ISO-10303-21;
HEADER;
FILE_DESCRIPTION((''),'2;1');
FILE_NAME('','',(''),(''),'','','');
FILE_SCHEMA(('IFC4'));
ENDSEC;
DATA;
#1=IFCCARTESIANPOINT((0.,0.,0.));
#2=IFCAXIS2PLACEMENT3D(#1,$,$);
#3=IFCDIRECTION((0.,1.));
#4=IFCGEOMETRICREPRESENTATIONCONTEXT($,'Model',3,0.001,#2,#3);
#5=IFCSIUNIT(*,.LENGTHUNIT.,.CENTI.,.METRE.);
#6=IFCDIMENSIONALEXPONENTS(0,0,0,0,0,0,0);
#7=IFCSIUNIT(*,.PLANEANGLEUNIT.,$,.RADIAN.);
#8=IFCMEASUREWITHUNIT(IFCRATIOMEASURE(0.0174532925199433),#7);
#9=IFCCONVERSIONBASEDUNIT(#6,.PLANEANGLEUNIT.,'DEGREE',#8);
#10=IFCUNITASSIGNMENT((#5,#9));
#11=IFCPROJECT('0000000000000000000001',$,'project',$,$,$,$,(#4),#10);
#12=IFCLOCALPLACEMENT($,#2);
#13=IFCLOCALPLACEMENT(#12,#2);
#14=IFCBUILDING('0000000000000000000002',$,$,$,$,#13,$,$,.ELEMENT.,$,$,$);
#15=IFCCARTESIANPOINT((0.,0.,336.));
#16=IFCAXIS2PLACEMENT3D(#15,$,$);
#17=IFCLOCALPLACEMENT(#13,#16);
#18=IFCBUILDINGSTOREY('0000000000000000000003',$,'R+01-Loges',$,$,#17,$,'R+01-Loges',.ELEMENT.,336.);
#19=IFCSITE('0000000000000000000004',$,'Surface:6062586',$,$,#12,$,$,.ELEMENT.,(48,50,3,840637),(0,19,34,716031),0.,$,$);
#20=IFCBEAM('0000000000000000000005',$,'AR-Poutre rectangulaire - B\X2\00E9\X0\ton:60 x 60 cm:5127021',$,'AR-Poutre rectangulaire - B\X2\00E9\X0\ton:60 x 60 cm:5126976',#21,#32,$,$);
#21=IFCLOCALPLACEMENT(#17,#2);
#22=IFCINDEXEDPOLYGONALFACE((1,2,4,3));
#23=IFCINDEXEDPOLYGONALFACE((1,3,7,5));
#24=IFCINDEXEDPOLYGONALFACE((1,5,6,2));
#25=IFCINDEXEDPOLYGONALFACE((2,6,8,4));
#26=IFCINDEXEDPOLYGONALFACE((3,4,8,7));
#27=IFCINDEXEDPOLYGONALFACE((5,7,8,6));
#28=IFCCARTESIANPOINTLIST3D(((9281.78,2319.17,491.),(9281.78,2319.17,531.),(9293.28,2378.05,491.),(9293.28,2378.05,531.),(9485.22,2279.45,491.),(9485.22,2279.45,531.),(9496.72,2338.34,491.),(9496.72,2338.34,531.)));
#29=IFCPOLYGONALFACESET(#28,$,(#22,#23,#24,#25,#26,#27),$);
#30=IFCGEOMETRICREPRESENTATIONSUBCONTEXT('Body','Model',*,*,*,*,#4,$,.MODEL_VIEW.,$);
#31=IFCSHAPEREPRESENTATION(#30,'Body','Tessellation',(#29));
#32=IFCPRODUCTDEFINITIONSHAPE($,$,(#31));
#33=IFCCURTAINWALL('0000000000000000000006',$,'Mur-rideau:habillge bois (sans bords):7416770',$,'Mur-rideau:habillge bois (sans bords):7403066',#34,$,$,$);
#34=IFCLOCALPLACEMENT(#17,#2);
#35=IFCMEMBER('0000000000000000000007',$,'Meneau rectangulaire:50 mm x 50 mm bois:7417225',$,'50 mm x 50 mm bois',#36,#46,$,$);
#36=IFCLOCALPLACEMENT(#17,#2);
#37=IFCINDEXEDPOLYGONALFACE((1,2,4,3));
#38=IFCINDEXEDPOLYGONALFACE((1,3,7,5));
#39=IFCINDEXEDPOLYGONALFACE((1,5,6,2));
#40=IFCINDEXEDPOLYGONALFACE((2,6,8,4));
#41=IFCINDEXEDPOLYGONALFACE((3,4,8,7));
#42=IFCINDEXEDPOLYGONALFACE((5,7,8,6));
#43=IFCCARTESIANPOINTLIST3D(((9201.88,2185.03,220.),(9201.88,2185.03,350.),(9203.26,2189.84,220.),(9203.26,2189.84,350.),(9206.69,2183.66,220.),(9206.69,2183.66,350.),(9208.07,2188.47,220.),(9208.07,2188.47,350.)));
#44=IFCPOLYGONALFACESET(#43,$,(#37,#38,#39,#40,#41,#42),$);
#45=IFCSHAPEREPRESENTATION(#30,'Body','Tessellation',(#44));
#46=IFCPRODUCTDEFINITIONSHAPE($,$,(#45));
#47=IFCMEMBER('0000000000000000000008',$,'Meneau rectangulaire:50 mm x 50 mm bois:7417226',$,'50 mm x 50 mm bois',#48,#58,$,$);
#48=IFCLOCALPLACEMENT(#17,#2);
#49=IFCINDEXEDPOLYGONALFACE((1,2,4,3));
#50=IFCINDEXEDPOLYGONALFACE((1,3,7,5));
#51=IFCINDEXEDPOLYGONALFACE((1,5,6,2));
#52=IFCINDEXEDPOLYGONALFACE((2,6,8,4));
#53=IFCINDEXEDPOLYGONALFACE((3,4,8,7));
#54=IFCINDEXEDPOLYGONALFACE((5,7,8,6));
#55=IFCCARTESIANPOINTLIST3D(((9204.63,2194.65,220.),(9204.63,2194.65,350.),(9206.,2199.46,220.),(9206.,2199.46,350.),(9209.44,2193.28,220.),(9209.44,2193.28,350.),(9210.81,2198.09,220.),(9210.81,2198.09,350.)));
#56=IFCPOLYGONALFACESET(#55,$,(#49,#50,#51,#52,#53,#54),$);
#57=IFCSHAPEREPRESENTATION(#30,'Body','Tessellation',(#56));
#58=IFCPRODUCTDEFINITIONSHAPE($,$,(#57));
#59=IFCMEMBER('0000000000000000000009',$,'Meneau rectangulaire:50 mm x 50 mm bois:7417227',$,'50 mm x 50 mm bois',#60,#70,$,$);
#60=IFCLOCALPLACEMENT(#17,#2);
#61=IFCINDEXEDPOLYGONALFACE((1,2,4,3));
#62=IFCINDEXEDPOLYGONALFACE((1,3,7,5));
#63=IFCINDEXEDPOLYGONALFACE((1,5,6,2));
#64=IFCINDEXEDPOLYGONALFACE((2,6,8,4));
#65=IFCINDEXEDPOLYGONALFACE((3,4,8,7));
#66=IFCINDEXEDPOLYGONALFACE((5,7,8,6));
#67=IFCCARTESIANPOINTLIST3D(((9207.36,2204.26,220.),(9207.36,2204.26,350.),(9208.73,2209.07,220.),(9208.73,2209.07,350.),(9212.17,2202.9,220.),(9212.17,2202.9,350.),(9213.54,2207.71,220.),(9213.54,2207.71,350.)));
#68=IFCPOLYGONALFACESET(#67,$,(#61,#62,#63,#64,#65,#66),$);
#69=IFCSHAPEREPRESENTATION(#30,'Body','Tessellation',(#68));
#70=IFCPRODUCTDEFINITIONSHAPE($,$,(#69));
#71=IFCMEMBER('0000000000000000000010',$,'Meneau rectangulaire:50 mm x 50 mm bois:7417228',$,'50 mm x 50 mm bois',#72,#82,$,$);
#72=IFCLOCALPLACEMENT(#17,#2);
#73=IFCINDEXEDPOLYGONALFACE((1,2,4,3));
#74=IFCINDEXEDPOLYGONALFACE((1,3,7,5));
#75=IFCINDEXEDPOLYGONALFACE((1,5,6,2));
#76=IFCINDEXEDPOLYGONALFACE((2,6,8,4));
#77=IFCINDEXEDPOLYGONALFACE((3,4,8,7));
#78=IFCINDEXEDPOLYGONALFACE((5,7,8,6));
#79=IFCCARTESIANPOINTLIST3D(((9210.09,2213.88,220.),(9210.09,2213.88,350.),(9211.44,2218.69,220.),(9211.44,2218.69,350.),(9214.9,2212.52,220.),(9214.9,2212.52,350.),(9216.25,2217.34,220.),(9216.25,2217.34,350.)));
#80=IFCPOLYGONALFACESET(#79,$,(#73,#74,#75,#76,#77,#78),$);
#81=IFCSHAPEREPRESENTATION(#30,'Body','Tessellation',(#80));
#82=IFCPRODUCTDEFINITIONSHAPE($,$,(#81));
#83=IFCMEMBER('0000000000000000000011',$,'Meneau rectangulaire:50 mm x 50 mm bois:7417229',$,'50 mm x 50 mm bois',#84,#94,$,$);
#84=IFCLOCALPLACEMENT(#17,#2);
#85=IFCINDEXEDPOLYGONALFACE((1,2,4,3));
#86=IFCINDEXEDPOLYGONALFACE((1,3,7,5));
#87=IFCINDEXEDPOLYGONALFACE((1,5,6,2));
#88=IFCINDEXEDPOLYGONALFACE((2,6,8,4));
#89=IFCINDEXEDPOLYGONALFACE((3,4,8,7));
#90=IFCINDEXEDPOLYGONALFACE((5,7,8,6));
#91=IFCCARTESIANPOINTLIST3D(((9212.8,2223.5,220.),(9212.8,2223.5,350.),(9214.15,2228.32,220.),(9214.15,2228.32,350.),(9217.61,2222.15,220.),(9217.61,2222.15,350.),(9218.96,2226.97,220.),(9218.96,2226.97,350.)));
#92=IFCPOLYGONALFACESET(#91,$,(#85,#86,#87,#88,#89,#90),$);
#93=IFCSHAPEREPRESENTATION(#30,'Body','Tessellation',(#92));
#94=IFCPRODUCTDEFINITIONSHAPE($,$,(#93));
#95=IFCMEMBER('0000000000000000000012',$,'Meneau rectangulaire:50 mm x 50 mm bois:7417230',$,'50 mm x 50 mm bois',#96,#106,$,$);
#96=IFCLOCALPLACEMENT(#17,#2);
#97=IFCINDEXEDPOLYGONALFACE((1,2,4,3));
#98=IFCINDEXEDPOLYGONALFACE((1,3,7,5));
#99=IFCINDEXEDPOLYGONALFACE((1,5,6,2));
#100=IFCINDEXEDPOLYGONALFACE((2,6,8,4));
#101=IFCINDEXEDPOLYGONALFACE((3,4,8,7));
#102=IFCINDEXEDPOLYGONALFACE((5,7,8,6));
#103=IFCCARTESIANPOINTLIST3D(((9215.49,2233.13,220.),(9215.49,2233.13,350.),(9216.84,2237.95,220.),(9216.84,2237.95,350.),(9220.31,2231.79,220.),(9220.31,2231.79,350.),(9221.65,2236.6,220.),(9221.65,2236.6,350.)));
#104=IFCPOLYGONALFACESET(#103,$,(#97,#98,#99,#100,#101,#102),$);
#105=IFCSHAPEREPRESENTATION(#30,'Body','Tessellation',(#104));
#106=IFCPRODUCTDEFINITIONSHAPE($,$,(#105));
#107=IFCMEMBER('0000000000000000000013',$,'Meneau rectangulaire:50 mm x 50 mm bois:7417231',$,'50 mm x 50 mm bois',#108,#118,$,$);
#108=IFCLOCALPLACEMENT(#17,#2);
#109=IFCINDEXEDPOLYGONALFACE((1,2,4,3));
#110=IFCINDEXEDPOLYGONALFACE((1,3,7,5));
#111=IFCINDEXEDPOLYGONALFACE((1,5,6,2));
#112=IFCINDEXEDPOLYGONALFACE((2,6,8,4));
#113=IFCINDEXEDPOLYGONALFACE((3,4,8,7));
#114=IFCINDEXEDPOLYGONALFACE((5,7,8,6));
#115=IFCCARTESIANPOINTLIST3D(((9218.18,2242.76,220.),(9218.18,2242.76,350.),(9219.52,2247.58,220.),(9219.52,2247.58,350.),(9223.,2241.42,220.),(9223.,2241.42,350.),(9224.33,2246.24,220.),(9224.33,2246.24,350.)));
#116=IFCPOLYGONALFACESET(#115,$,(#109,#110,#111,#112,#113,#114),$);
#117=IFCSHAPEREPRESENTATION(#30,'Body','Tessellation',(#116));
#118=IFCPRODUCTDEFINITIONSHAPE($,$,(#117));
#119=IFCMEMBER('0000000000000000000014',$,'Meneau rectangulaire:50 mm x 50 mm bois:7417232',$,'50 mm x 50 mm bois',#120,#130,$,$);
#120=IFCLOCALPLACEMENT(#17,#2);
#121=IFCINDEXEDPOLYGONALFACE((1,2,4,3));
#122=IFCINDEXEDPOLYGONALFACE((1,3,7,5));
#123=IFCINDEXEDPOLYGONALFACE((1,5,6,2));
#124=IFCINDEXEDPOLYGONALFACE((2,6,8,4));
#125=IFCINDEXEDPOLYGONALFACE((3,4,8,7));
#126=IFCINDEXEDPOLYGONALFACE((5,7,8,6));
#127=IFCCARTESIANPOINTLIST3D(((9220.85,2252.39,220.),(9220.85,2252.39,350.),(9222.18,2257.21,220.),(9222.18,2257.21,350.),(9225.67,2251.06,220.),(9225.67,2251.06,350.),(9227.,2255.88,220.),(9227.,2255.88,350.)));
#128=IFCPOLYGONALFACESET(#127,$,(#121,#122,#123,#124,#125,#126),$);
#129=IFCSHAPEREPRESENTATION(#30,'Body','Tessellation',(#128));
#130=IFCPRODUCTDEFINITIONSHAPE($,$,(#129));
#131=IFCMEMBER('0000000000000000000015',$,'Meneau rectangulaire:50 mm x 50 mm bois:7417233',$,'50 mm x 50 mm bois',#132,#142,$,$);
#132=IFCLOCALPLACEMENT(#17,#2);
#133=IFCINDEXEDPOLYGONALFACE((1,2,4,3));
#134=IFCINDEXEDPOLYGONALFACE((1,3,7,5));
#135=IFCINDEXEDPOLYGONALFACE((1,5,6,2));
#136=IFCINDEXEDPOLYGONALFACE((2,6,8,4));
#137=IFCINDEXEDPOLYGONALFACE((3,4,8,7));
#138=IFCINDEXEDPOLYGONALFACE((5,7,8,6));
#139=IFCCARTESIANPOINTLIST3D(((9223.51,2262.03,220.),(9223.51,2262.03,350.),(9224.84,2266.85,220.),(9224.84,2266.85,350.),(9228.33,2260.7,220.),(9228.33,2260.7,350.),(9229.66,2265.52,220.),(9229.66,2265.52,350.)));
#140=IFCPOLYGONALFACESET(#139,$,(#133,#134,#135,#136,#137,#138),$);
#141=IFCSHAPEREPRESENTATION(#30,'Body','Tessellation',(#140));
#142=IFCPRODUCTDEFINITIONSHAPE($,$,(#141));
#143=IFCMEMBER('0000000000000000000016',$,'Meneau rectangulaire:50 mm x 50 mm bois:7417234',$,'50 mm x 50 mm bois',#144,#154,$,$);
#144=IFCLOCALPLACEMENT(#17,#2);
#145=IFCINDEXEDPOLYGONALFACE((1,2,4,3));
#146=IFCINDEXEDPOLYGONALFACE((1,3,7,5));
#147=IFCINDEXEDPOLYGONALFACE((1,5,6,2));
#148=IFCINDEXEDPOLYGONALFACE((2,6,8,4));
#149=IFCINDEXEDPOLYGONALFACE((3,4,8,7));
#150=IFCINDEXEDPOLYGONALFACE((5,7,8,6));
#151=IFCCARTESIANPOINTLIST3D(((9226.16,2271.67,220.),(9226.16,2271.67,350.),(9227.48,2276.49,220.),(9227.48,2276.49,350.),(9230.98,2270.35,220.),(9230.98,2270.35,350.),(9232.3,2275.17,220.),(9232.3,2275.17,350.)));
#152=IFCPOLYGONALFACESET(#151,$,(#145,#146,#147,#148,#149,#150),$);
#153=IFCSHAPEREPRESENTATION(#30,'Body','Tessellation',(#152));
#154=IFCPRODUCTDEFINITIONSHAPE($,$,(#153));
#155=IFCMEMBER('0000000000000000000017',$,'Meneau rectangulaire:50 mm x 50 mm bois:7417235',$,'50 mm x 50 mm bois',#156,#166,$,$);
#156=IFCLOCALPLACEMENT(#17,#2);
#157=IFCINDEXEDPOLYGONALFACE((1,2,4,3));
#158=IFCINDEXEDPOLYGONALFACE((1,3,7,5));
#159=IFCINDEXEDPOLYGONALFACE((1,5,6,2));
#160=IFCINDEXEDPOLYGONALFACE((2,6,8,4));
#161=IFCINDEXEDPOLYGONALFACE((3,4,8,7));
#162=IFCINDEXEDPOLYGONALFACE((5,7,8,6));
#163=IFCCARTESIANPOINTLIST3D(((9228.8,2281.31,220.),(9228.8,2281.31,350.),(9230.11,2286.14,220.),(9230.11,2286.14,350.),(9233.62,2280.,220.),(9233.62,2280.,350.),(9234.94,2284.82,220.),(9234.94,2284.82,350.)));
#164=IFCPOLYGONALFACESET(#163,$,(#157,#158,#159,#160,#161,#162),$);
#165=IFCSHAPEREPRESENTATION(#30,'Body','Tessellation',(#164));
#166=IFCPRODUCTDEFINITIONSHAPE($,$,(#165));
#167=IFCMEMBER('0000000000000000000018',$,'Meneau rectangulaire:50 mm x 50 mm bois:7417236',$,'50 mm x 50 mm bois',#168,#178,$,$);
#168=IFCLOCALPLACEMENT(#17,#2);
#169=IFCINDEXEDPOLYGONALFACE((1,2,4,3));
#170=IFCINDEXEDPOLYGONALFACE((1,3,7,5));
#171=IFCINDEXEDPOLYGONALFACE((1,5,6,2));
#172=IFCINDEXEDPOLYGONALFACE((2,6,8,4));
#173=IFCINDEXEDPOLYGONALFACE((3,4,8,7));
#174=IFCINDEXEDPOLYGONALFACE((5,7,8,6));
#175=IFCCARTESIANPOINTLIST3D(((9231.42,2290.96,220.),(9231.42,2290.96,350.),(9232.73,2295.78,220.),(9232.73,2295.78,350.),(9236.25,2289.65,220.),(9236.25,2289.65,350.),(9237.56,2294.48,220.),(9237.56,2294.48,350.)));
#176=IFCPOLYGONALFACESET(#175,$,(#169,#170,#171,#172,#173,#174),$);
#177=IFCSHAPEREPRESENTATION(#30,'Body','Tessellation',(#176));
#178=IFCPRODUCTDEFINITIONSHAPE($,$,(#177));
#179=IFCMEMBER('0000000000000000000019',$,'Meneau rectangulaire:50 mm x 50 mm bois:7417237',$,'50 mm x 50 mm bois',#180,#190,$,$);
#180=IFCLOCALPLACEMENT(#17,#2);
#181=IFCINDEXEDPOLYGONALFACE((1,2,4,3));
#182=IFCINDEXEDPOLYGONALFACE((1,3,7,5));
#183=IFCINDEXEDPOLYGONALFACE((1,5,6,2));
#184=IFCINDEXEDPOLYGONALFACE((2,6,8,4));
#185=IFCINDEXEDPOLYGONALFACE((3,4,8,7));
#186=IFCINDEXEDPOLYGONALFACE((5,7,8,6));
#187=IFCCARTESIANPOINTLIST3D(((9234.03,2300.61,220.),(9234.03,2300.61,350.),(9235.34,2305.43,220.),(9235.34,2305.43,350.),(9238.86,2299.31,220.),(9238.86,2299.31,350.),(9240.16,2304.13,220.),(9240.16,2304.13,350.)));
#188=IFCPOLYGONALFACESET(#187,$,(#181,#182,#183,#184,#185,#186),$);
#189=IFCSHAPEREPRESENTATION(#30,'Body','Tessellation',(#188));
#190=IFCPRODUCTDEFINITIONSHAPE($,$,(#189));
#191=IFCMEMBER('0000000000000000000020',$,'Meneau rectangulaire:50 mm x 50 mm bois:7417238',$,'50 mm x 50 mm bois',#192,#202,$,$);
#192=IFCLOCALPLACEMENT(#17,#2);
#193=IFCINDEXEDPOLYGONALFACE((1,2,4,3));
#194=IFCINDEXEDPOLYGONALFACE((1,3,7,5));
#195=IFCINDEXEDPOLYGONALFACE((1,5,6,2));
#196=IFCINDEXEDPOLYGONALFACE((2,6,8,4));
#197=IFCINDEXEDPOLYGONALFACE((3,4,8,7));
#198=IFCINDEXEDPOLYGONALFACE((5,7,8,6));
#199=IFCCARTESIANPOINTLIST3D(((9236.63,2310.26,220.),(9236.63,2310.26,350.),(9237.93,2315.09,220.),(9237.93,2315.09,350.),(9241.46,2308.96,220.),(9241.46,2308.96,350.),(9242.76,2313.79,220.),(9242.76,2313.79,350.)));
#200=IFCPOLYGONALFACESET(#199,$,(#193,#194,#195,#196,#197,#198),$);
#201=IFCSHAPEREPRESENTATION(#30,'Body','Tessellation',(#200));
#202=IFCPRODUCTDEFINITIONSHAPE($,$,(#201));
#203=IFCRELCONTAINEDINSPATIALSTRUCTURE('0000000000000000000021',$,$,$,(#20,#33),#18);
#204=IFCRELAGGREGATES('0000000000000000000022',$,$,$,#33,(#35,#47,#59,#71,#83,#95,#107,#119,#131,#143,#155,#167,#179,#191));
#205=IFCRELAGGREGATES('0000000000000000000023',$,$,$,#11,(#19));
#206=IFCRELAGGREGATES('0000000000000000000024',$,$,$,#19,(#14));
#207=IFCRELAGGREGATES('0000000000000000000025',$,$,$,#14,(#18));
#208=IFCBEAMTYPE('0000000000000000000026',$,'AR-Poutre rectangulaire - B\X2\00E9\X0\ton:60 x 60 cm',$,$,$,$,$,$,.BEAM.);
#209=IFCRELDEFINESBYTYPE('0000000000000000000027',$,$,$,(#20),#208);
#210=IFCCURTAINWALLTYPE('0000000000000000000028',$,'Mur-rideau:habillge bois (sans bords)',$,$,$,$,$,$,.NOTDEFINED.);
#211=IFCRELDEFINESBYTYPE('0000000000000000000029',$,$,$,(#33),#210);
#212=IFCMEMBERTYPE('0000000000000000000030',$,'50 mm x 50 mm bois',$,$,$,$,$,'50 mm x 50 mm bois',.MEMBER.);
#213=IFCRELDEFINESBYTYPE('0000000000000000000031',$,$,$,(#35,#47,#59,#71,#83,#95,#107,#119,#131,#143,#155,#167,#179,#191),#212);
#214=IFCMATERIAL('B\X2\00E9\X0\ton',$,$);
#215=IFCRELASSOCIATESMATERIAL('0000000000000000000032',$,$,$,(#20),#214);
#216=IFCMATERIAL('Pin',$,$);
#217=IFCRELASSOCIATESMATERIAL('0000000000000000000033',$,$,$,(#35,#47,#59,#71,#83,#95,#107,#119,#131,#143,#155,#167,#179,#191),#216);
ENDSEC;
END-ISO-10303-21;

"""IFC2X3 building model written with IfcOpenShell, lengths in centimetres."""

from ifc_helpers import new_model, entity, si_unit, converted_unit, direction, frame, origin, origin_2d_with_axis, place, context, subcontext, project, spatial, rectangle, extrude, source, transform, mapped, material, type_object, type_shapes, element, aggregate, save


model = new_model("IFC2X3")

# Units and contexts
model_context = context("Model", 3, precision=0.001, world=origin(), true_north=direction((0.0, 1.0)))
body_context = subcontext(model_context, "Body", "Model", "MODEL_VIEW")
ifc_project = project(units=[si_unit("LENGTHUNIT", "METRE", prefix="CENTI"), converted_unit("PLANEANGLEUNIT", "DEGREE", entity("IfcRatioMeasure", 0.0174532925199433), si_unit("PLANEANGLEUNIT", "RADIAN"), dimensions=[0, 0, 0, 0, 0, 0, 0])], contexts=[model_context])

# Site, building, storey
site_placement = place(None, origin())
site = spatial("IfcSite", under=ifc_project, at=site_placement, Name="Surface:6062586", CompositionType="ELEMENT", RefLatitude=(48, 50, 3, 840637), RefLongitude=(0, 19, 34, 716031), RefElevation=0.0)
building_placement = place(site_placement, origin())
building = spatial("IfcBuilding", under=site, at=building_placement, CompositionType="ELEMENT")
storey_placement = place(building_placement, frame((0.0, 0.0, 336.0)))
storey = spatial("IfcBuildingStorey", under=building, at=storey_placement, Name="R+01-Loges", LongName="R+01-Loges", CompositionType="ELEMENT", Elevation=336.0)

# Beam
ifc_material_1 = material(Name="Béton")
beam_type = type_object("IfcBeamType", Name="AR-Poutre rectangulaire - Béton:60 x 60 cm", PredefinedType="BEAM")
beam_placement = place(storey_placement, frame((9287.53, 2348.61, 551.0), z_axis=(0.0, 0.0, 1.0), x_axis=(0.981469, -0.19162, 0.0)))
element("IfcBeam", 1, at=beam_placement, inside=storey, type_object=beam_type, material=ifc_material_1, Name="AR-Poutre rectangulaire - Béton:60 x 60 cm:5127021", ObjectType="AR-Poutre rectangulaire - Béton:60 x 60 cm:5126976", context=body_context, shape_type="SweptSolid", body=[
    extrude(rectangle(XDim=40.0, YDim=60.0, at=origin_2d_with_axis()), frame((0.0, 0.0, -40.0), z_axis=(1.0, 0.0, 0.0), x_axis=(0.0, 0.0, -1.0)), (0.0, 0.0, 1.0), 207.28),
])

# Curtain wall, members
curtain_wall_type = type_object("IfcCurtainWallType", Name="Mur-rideau:habillge bois (sans bords)", PredefinedType="NOTDEFINED")
curtain_wall_placement = place(storey_placement, frame((0.0, 0.0, -336.0)))
curtain_wall = element("IfcCurtainWall", 2, at=curtain_wall_placement, inside=storey, type_object=curtain_wall_type, Name="Mur-rideau:habillge bois (sans bords):7416770", ObjectType="Mur-rideau:habillge bois (sans bords):7403066")
ifc_material_2 = material(Name="Pin")
member_type = type_object("IfcMemberType", Name="50 mm x 50 mm bois", ElementType="50 mm x 50 mm bois", PredefinedType="MEMBER")
shared_shape = source(origin(), body_context, "Body", "SweptSolid", [
    extrude(rectangle(XDim=5.0, YDim=5.0, at=origin_2d_with_axis()), frame((0.0, 0.0, -130.0), z_axis=(0.0, 0.0, 1.0), x_axis=(0.0, -1.0, 0.0)), (0.0, 0.0, 1.0), 130.0),
])
type_shapes(member_type, [shared_shape])
member_1_placement = place(storey_placement, frame((9204.98, 2186.75, 220.0), z_axis=(0.0, 0.0, -1.0), x_axis=(0.274985, 0.961448, 0.0)))
member_1 = element("IfcMember", 3, at=member_1_placement, type_object=member_type, material=ifc_material_2, Name="Meneau rectangulaire:50 mm x 50 mm bois:7417225", ObjectType="50 mm x 50 mm bois", context=body_context, shape_type="MappedRepresentation", body=[
    mapped(shared_shape, transform((0.0, 0.0, 0.0), scale=1.0)),
])
member_2_placement = place(storey_placement, frame((9207.72, 2196.37, 220.0), z_axis=(0.0, 0.0, -1.0), x_axis=(0.27377, 0.961795, 0.0)))
member_2 = element("IfcMember", 4, at=member_2_placement, type_object=member_type, material=ifc_material_2, Name="Meneau rectangulaire:50 mm x 50 mm bois:7417226", ObjectType="50 mm x 50 mm bois", context=body_context, shape_type="MappedRepresentation", body=[
    mapped(shared_shape, transform((0.0, 0.0, 0.0), scale=1.0)),
])
member_3_placement = place(storey_placement, frame((9210.45, 2205.99, 220.0), z_axis=(0.0, 0.0, -1.0), x_axis=(0.272555, 0.96214, 0.0)))
member_3 = element("IfcMember", 5, at=member_3_placement, type_object=member_type, material=ifc_material_2, Name="Meneau rectangulaire:50 mm x 50 mm bois:7417227", ObjectType="50 mm x 50 mm bois", context=body_context, shape_type="MappedRepresentation", body=[
    mapped(shared_shape, transform((0.0, 0.0, 0.0), scale=1.0)),
])
member_4_placement = place(storey_placement, frame((9213.17, 2215.61, 220.0), z_axis=(0.0, 0.0, -1.0), x_axis=(0.271339, 0.962484, 0.0)))
member_4 = element("IfcMember", 6, at=member_4_placement, type_object=member_type, material=ifc_material_2, Name="Meneau rectangulaire:50 mm x 50 mm bois:7417228", ObjectType="50 mm x 50 mm bois", context=body_context, shape_type="MappedRepresentation", body=[
    mapped(shared_shape, transform((0.0, 0.0, 0.0), scale=1.0)),
])
member_5_placement = place(storey_placement, frame((9215.88, 2225.24, 220.0), z_axis=(0.0, 0.0, -1.0), x_axis=(0.270123, 0.962826, 0.0)))
member_5 = element("IfcMember", 7, at=member_5_placement, type_object=member_type, material=ifc_material_2, Name="Meneau rectangulaire:50 mm x 50 mm bois:7417229", ObjectType="50 mm x 50 mm bois", context=body_context, shape_type="MappedRepresentation", body=[
    mapped(shared_shape, transform((0.0, 0.0, 0.0), scale=1.0)),
])
member_6_placement = place(storey_placement, frame((9218.57, 2234.87, 220.0), z_axis=(0.0, 0.0, -1.0), x_axis=(0.268907, 0.963166, 0.0)))
member_6 = element("IfcMember", 8, at=member_6_placement, type_object=member_type, material=ifc_material_2, Name="Meneau rectangulaire:50 mm x 50 mm bois:7417230", ObjectType="50 mm x 50 mm bois", context=body_context, shape_type="MappedRepresentation", body=[
    mapped(shared_shape, transform((0.0, 0.0, 0.0), scale=1.0)),
])
member_7_placement = place(storey_placement, frame((9221.26, 2244.5, 220.0), z_axis=(0.0, 0.0, -1.0), x_axis=(0.267689, 0.963505, 0.0)))
member_7 = element("IfcMember", 9, at=member_7_placement, type_object=member_type, material=ifc_material_2, Name="Meneau rectangulaire:50 mm x 50 mm bois:7417231", ObjectType="50 mm x 50 mm bois", context=body_context, shape_type="MappedRepresentation", body=[
    mapped(shared_shape, transform((0.0, 0.0, 0.0), scale=1.0)),
])
member_8_placement = place(storey_placement, frame((9223.93, 2254.14, 220.0), z_axis=(0.0, 0.0, -1.0), x_axis=(0.266472, 0.963843, 0.0)))
member_8 = element("IfcMember", 10, at=member_8_placement, type_object=member_type, material=ifc_material_2, Name="Meneau rectangulaire:50 mm x 50 mm bois:7417232", ObjectType="50 mm x 50 mm bois", context=body_context, shape_type="MappedRepresentation", body=[
    mapped(shared_shape, transform((0.0, 0.0, 0.0), scale=1.0)),
])
member_9_placement = place(storey_placement, frame((9226.59, 2263.78, 220.0), z_axis=(0.0, 0.0, -1.0), x_axis=(0.265254, 0.964179, 0.0)))
member_9 = element("IfcMember", 11, at=member_9_placement, type_object=member_type, material=ifc_material_2, Name="Meneau rectangulaire:50 mm x 50 mm bois:7417233", ObjectType="50 mm x 50 mm bois", context=body_context, shape_type="MappedRepresentation", body=[
    mapped(shared_shape, transform((0.0, 0.0, 0.0), scale=1.0)),
])
member_10_placement = place(storey_placement, frame((9229.23, 2273.42, 220.0), z_axis=(0.0, 0.0, -1.0), x_axis=(0.264036, 0.964513, 0.0)))
member_10 = element("IfcMember", 12, at=member_10_placement, type_object=member_type, material=ifc_material_2, Name="Meneau rectangulaire:50 mm x 50 mm bois:7417234", ObjectType="50 mm x 50 mm bois", context=body_context, shape_type="MappedRepresentation", body=[
    mapped(shared_shape, transform((0.0, 0.0, 0.0), scale=1.0)),
])
member_11_placement = place(storey_placement, frame((9231.87, 2283.07, 220.0), z_axis=(0.0, 0.0, -1.0), x_axis=(0.262817, 0.964846, 0.0)))
member_11 = element("IfcMember", 13, at=member_11_placement, type_object=member_type, material=ifc_material_2, Name="Meneau rectangulaire:50 mm x 50 mm bois:7417235", ObjectType="50 mm x 50 mm bois", context=body_context, shape_type="MappedRepresentation", body=[
    mapped(shared_shape, transform((0.0, 0.0, 0.0), scale=1.0)),
])
member_12_placement = place(storey_placement, frame((9234.49, 2292.72, 220.0), z_axis=(0.0, 0.0, -1.0), x_axis=(0.261598, 0.965177, 0.0)))
member_12 = element("IfcMember", 14, at=member_12_placement, type_object=member_type, material=ifc_material_2, Name="Meneau rectangulaire:50 mm x 50 mm bois:7417236", ObjectType="50 mm x 50 mm bois", context=body_context, shape_type="MappedRepresentation", body=[
    mapped(shared_shape, transform((0.0, 0.0, 0.0), scale=1.0)),
])
member_13_placement = place(storey_placement, frame((9237.1, 2302.37, 220.0), z_axis=(0.0, 0.0, -1.0), x_axis=(0.260378, 0.965507, 0.0)))
member_13 = element("IfcMember", 15, at=member_13_placement, type_object=member_type, material=ifc_material_2, Name="Meneau rectangulaire:50 mm x 50 mm bois:7417237", ObjectType="50 mm x 50 mm bois", context=body_context, shape_type="MappedRepresentation", body=[
    mapped(shared_shape, transform((0.0, 0.0, 0.0), scale=1.0)),
])
member_14_placement = place(storey_placement, frame((9239.7, 2312.03, 220.0), z_axis=(0.0, 0.0, -1.0), x_axis=(0.259158, 0.965835, 0.0)))
member_14 = element("IfcMember", 16, at=member_14_placement, type_object=member_type, material=ifc_material_2, Name="Meneau rectangulaire:50 mm x 50 mm bois:7417238", ObjectType="50 mm x 50 mm bois", context=body_context, shape_type="MappedRepresentation", body=[
    mapped(shared_shape, transform((0.0, 0.0, 0.0), scale=1.0)),
])
aggregate(curtain_wall, [member_1, member_2, member_3, member_4, member_5, member_6, member_7, member_8, member_9, member_10, member_11, member_12, member_13, member_14])

save(model, "model.ifc")
